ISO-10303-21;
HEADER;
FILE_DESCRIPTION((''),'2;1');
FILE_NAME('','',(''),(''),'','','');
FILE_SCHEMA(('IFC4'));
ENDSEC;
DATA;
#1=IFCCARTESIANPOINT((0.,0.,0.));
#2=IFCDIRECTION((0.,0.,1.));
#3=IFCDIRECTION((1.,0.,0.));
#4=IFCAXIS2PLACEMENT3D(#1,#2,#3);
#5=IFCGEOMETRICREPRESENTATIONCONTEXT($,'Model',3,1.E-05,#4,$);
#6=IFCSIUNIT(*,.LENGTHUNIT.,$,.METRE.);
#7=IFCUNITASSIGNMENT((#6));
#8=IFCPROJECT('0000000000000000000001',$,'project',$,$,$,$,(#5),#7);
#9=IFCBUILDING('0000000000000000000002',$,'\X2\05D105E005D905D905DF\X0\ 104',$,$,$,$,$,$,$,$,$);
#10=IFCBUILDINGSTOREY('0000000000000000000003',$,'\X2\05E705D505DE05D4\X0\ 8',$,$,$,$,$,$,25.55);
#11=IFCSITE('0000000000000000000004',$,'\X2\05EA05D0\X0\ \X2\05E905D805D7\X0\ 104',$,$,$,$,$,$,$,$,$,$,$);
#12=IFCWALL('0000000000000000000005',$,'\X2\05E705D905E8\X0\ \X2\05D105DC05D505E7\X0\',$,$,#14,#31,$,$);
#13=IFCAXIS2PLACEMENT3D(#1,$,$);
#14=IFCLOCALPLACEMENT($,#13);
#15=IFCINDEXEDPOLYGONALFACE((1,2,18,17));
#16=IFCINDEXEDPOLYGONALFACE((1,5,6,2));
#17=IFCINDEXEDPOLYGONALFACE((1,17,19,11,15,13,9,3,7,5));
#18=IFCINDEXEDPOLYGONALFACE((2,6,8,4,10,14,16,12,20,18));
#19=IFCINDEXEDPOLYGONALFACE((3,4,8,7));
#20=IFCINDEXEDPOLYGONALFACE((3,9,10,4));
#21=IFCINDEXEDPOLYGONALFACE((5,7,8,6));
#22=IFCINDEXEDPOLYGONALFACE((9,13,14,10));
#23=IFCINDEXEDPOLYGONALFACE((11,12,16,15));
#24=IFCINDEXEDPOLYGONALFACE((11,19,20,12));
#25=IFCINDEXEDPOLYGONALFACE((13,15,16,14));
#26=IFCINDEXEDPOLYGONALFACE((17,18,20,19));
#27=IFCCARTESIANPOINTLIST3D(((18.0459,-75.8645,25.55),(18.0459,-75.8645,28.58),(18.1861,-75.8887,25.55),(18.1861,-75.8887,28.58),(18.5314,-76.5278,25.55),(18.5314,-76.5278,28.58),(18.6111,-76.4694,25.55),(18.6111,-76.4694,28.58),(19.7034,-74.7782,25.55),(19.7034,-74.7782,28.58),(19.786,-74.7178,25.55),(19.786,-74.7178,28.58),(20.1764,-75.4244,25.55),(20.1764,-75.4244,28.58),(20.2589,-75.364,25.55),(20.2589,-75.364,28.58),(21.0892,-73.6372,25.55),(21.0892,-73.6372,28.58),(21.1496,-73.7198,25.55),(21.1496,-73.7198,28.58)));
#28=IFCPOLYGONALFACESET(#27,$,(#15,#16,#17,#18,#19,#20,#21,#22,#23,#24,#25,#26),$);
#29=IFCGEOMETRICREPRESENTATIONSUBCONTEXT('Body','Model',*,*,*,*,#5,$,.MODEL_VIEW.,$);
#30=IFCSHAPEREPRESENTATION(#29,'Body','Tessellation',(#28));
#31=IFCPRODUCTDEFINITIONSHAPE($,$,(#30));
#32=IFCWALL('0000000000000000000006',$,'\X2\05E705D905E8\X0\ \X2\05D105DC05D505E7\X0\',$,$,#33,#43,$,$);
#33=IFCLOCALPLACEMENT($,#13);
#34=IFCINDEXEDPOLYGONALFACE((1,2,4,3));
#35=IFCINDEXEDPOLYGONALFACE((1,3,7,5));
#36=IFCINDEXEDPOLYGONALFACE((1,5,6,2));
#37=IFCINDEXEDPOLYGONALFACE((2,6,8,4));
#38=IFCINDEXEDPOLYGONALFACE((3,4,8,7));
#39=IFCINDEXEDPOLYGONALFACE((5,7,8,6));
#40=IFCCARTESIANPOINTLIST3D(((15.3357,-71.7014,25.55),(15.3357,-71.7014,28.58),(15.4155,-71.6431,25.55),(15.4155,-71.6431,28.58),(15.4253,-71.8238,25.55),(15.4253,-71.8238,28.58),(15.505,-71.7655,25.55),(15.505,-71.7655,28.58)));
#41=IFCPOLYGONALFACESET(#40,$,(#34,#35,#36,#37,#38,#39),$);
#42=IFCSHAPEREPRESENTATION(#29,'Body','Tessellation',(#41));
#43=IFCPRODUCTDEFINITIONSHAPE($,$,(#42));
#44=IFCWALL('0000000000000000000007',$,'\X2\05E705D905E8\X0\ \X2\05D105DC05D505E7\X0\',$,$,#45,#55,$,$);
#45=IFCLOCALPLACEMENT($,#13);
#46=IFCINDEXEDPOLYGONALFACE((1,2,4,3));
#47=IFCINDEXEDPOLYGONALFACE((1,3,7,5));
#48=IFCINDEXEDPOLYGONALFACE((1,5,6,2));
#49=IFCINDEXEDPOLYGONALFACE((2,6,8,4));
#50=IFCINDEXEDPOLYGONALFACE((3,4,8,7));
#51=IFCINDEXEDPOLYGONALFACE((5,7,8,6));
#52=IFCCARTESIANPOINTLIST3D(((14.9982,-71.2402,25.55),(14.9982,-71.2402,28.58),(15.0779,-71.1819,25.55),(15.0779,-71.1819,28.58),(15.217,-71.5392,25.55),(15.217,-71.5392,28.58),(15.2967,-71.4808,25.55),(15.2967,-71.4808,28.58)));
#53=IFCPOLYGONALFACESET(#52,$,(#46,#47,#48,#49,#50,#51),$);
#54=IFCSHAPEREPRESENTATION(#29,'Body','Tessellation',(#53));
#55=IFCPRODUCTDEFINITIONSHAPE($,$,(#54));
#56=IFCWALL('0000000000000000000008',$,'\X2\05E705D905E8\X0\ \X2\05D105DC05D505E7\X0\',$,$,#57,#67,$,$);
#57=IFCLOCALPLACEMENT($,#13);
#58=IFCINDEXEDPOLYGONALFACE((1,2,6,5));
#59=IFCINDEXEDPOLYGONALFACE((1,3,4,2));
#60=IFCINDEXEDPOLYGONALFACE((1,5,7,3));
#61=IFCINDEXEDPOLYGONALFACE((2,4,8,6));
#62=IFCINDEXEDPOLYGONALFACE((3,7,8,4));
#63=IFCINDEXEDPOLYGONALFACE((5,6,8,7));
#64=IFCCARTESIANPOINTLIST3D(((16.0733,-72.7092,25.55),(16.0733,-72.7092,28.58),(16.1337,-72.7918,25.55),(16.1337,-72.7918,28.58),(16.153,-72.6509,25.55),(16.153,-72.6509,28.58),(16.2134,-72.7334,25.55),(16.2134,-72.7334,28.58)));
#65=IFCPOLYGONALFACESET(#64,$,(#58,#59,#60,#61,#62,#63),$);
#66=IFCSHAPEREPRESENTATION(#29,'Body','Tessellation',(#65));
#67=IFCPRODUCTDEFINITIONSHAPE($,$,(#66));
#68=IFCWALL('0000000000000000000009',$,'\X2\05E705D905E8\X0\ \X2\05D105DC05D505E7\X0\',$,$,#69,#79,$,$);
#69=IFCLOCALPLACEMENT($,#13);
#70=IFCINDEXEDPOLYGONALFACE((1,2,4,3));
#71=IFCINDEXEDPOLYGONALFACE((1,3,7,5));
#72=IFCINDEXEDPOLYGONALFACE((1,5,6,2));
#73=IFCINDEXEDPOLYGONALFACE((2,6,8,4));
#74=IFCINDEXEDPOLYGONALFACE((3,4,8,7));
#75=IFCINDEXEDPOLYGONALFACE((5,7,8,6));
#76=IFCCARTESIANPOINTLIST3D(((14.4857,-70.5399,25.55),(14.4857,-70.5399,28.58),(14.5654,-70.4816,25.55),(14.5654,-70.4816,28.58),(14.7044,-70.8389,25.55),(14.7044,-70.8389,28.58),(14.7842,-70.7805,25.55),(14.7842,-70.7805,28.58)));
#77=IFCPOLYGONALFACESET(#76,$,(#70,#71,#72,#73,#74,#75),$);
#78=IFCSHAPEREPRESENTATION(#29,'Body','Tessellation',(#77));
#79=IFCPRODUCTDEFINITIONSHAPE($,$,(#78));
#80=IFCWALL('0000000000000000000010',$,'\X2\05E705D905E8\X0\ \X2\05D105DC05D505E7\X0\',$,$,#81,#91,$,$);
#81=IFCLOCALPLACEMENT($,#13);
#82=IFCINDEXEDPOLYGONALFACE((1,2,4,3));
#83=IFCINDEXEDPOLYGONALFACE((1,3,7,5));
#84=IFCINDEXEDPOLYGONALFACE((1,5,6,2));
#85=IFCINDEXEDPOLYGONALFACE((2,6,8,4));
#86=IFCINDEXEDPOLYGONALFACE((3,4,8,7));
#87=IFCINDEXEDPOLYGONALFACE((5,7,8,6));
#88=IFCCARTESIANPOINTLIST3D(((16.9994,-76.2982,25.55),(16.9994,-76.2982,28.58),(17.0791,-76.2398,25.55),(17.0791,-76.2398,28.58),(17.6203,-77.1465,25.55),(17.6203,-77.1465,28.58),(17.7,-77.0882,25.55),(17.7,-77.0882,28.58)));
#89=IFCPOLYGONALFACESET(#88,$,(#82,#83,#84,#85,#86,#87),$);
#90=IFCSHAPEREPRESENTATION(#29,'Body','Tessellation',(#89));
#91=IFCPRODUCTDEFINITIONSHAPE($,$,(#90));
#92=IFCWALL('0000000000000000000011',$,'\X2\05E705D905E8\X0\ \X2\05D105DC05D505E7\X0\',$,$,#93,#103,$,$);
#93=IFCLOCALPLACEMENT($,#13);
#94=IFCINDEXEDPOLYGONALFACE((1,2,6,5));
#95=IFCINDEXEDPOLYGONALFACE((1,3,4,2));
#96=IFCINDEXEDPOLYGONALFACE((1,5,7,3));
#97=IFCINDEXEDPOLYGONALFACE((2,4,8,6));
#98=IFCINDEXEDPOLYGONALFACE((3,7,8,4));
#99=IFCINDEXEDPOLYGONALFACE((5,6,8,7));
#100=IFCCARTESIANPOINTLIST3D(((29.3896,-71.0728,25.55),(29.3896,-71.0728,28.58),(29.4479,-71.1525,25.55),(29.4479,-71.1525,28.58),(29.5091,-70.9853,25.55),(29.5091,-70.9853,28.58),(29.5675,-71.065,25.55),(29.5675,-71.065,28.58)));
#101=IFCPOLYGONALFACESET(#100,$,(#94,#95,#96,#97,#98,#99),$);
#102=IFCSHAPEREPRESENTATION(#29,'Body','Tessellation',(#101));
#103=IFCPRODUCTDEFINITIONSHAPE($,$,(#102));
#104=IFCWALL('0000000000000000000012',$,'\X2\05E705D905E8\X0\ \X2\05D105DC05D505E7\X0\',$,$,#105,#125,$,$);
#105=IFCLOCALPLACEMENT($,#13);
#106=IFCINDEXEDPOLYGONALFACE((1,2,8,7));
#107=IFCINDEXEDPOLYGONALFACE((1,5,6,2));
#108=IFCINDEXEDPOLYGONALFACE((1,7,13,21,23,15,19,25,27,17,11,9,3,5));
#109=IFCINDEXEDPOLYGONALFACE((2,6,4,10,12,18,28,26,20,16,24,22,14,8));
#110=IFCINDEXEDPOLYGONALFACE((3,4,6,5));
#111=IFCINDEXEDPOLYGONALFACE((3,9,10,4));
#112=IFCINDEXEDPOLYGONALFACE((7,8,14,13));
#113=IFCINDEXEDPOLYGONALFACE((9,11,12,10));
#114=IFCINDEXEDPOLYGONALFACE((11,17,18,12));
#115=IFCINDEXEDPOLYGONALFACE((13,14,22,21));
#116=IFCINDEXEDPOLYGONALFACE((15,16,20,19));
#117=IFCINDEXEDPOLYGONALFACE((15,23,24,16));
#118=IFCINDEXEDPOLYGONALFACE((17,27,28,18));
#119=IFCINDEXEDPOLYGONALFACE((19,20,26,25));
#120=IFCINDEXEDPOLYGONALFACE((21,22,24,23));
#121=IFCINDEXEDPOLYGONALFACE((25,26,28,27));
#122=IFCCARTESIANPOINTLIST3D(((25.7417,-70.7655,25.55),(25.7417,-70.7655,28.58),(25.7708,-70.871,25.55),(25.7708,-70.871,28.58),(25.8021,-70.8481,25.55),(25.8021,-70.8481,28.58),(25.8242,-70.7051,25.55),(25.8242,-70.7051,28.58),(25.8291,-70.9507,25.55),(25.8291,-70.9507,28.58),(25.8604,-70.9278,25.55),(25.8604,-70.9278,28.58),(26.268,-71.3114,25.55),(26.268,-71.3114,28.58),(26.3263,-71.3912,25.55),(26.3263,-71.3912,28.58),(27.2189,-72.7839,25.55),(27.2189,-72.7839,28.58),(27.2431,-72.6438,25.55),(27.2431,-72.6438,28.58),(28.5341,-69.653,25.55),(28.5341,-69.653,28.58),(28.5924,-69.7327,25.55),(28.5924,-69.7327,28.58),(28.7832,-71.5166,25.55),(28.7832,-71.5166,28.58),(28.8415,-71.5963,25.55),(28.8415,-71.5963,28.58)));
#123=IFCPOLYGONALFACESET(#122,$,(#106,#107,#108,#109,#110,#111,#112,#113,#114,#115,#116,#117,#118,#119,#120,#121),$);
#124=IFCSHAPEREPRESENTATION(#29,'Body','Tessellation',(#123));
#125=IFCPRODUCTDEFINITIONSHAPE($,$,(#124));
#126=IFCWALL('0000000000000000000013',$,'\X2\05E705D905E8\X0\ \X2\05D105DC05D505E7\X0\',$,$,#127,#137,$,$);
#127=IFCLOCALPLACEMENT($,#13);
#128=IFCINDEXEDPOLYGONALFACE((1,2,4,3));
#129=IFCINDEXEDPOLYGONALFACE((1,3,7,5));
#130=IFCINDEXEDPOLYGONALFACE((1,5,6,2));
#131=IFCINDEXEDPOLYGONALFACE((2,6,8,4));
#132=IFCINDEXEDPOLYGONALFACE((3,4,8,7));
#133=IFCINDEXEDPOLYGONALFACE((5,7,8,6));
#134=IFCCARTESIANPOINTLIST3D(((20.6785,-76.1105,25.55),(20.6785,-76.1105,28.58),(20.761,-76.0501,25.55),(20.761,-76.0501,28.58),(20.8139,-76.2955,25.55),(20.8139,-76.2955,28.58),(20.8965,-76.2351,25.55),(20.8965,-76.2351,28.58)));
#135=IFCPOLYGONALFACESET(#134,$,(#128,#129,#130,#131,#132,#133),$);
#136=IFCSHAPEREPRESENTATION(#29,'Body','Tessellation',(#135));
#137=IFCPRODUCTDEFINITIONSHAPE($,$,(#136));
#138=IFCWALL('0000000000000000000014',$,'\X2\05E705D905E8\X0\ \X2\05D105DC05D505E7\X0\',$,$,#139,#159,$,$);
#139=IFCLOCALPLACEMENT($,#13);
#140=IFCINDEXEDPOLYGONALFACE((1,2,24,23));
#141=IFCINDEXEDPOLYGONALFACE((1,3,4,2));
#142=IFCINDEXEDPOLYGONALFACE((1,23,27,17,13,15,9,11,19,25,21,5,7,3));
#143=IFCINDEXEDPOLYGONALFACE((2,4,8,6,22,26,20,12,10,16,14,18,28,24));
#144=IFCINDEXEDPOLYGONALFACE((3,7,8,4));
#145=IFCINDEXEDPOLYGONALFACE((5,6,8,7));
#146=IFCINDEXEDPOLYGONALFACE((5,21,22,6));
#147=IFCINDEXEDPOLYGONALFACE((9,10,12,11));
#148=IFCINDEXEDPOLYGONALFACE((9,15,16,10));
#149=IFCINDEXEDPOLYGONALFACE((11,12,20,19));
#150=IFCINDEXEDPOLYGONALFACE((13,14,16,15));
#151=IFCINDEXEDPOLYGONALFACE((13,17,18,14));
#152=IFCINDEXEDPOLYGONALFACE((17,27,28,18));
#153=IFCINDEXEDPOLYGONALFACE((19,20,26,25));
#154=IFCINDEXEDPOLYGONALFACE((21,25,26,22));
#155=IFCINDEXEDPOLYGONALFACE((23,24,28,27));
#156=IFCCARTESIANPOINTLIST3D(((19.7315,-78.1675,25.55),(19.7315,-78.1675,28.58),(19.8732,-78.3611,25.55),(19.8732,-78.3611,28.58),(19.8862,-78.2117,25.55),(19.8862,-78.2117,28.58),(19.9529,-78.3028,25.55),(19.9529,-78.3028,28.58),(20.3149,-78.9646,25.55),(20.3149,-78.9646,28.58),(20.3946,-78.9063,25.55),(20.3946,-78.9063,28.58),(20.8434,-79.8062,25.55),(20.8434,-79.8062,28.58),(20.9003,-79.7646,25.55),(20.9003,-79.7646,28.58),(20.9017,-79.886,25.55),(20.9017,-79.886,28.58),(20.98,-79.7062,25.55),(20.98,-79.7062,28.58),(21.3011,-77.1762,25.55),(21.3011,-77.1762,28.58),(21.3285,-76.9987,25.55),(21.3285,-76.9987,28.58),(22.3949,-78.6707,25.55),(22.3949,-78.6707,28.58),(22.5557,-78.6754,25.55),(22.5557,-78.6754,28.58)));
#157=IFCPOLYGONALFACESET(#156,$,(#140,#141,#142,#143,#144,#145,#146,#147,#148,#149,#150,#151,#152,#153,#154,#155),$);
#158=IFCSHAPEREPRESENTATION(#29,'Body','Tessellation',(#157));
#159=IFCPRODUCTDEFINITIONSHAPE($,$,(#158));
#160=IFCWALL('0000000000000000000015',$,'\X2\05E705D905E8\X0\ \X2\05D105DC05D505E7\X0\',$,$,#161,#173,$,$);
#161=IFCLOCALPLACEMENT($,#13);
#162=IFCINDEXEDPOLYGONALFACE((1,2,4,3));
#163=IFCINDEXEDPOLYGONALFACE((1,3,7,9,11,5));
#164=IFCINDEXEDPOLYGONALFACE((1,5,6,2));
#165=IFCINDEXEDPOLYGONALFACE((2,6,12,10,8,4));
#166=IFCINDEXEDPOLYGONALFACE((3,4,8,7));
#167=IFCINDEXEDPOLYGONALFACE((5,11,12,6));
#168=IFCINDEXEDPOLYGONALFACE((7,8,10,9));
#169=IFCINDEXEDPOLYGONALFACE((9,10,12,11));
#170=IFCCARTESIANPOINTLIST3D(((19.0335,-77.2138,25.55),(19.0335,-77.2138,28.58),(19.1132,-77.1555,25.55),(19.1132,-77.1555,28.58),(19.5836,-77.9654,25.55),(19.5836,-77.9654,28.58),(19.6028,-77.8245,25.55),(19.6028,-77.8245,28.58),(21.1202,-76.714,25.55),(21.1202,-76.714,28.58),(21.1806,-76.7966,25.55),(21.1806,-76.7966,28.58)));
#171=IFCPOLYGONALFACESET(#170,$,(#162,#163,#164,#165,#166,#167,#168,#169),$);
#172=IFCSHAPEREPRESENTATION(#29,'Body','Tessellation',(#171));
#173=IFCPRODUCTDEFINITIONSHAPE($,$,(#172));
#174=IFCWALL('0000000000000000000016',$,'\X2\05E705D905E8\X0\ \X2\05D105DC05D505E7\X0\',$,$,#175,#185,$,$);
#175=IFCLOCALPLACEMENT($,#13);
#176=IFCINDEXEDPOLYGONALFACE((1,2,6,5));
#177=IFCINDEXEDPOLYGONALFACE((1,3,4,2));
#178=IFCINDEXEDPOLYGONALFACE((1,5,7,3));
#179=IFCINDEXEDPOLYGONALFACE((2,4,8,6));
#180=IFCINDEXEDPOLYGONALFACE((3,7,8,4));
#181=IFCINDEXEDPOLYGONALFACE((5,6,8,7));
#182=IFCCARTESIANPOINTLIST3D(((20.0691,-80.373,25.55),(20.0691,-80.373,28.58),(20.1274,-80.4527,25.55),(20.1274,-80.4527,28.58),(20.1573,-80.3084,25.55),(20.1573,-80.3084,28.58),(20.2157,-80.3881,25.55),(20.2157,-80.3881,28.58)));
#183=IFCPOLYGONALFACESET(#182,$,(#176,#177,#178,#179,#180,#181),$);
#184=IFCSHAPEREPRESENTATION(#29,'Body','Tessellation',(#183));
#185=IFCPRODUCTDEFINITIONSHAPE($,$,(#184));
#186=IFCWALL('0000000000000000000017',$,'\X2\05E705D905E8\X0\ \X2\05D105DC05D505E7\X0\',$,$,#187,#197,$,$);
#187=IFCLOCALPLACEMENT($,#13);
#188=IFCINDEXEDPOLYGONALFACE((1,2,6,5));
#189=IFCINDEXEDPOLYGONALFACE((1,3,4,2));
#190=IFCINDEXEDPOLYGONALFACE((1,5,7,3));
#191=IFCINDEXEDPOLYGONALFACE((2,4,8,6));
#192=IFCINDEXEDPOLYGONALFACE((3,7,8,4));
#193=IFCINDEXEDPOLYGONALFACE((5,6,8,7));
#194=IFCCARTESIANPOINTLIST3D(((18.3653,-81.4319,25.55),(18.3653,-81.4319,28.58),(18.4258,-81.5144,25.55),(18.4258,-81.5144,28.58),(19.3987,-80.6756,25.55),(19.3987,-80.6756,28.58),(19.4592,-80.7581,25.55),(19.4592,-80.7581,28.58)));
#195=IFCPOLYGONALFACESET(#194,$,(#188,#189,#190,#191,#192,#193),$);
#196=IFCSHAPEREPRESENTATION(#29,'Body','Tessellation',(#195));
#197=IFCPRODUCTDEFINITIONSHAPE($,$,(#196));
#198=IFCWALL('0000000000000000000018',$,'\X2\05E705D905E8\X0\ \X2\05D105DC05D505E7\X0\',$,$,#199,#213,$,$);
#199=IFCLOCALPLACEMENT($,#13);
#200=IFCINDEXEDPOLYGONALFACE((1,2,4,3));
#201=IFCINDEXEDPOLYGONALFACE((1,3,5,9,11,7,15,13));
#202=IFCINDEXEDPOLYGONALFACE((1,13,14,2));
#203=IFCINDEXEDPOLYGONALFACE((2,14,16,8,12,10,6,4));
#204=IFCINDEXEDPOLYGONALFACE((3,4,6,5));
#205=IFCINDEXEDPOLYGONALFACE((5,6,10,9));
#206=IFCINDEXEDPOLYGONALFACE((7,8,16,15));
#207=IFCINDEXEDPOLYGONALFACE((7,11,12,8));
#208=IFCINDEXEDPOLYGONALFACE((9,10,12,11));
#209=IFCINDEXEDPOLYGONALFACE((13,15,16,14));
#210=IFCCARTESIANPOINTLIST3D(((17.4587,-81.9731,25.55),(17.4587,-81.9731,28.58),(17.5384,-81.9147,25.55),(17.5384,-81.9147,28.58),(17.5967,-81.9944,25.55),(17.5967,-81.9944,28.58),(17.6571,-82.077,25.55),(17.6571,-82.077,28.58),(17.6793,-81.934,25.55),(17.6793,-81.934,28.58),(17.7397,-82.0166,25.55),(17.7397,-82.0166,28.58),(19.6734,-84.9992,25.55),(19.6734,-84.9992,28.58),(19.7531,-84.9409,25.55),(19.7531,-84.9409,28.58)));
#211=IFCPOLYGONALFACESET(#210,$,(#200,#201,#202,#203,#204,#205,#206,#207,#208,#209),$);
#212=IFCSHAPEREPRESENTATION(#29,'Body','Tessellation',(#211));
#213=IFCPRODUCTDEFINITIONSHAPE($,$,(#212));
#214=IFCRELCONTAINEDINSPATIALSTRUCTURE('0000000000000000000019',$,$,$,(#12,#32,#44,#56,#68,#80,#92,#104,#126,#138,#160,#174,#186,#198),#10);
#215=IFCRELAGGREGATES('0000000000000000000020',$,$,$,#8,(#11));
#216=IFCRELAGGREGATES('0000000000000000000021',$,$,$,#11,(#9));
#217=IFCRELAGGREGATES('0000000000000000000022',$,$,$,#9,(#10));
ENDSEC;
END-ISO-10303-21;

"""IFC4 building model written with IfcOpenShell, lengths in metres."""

from ifc_helpers import new_model, si_unit, frame, origin_with_axes, context, subcontext, project, spatial, polyline, outline, extrude, element, save


model = new_model("IFC4")

# Units and contexts
model_context = context("Model", 3, precision=1e-05, world=origin_with_axes())
body_context = subcontext(model_context, "Body", "Model", "MODEL_VIEW")
ifc_project = project(units=[si_unit("LENGTHUNIT", "METRE")], contexts=[model_context])

# Site, building, storey
site = spatial("IfcSite", under=ifc_project, Name="תא שטח 104")
building = spatial("IfcBuilding", under=site, Name="בניין 104")
storey = spatial("IfcBuildingStorey", under=building, Name="קומה 8", Elevation=25.55)

# Walls
element("IfcWall", 1, inside=storey, Name="קיר בלוק", context=body_context, shape_type="SweptSolid", body=[
    extrude(outline(polyline([(19.7034, -74.7782), (20.1764, -75.4244), (20.2589, -75.364), (19.786, -74.7178), (21.1496, -73.7198), (21.0892, -73.6372), (18.0459, -75.8645), (18.5314, -76.5278), (18.6111, -76.4694), (18.1861, -75.8887), (19.7034, -74.7782)])), frame((0.0, 0.0, 25.55)), (0.0, 0.0, 1.0), 3.03),
])
element("IfcWall", 2, inside=storey, Name="קיר בלוק", context=body_context, shape_type="SweptSolid", body=[
    extrude(outline(polyline([(15.3357, -71.7014), (15.4253, -71.8238), (15.505, -71.7655), (15.4155, -71.6431), (15.3357, -71.7014)])), frame((0.0, 0.0, 25.55)), (0.0, 0.0, 1.0), 3.03),
])
element("IfcWall", 3, inside=storey, Name="קיר בלוק", context=body_context, shape_type="SweptSolid", body=[
    extrude(outline(polyline([(15.0779, -71.1819), (14.9982, -71.2403), (15.217, -71.5392), (15.2967, -71.4808), (15.0779, -71.1819)])), frame((0.0, 0.0, 25.55)), (0.0, 0.0, 1.0), 3.03),
])
element("IfcWall", 4, inside=storey, Name="קיר בלוק", context=body_context, shape_type="SweptSolid", body=[
    extrude(outline(polyline([(16.2134, -72.7334), (16.153, -72.6509), (16.0733, -72.7092), (16.1337, -72.7918), (16.2134, -72.7334)])), frame((0.0, 0.0, 25.55)), (0.0, 0.0, 1.0), 3.03),
])
element("IfcWall", 5, inside=storey, Name="קיר בלוק", context=body_context, shape_type="SweptSolid", body=[
    extrude(outline(polyline([(14.7044, -70.8389), (14.7841, -70.7805), (14.5654, -70.4816), (14.4857, -70.5399), (14.7044, -70.8389)])), frame((0.0, 0.0, 25.55)), (0.0, 0.0, 1.0), 3.03),
])
element("IfcWall", 6, inside=storey, Name="קיר בלוק", context=body_context, shape_type="SweptSolid", body=[
    extrude(outline(polyline([(17.6203, -77.1465), (17.7, -77.0882), (17.0791, -76.2398), (16.9994, -76.2982), (17.6203, -77.1465)])), frame((0.0, 0.0, 25.55)), (0.0, 0.0, 1.0), 3.03),
])
element("IfcWall", 7, inside=storey, Name="קיר בלוק", context=body_context, shape_type="SweptSolid", body=[
    extrude(outline(polyline([(29.5675, -71.065), (29.5091, -70.9853), (29.3896, -71.0728), (29.4479, -71.1525), (29.5675, -71.065)])), frame((0.0, 0.0, 25.55)), (0.0, 0.0, 1.0), 3.03),
])
element("IfcWall", 8, inside=storey, Name="קיר בלוק", context=body_context, shape_type="SweptSolid", body=[
    extrude(outline(polyline([(25.8021, -70.8481), (25.7708, -70.871), (25.8291, -70.9507), (25.8604, -70.9278), (27.2189, -72.7839), (28.8415, -71.5963), (28.7832, -71.5166), (27.2431, -72.6438), (26.3263, -71.3912), (28.5924, -69.7327), (28.5341, -69.653), (26.268, -71.3114), (25.8242, -70.7051), (25.7417, -70.7655), (25.8021, -70.8481)])), frame((0.0, 0.0, 25.55)), (0.0, 0.0, 1.0), 3.03),
])
element("IfcWall", 9, inside=storey, Name="קיר בלוק", context=body_context, shape_type="SweptSolid", body=[
    extrude(outline(polyline([(20.8965, -76.2351), (20.761, -76.0501), (20.6785, -76.1105), (20.8139, -76.2955), (20.8965, -76.2351)])), frame((0.0, 0.0, 25.55)), (0.0, 0.0, 1.0), 3.03),
])
element("IfcWall", 10, inside=storey, Name="קיר בלוק", context=body_context, shape_type="SweptSolid", body=[
    extrude(outline(polyline([(21.3285, -76.9987), (19.7315, -78.1675), (19.8732, -78.3611), (19.9529, -78.3028), (19.8862, -78.2117), (21.3011, -77.1762), (22.3949, -78.6707), (20.98, -79.7062), (20.3946, -78.9063), (20.3149, -78.9646), (20.9003, -79.7646), (20.8434, -79.8062), (20.9017, -79.886), (22.5557, -78.6754), (21.3285, -76.9987)])), frame((0.0, 0.0, 25.55)), (0.0, 0.0, 1.0), 3.03),
])
element("IfcWall", 11, inside=storey, Name="קיר בלוק", context=body_context, shape_type="SweptSolid", body=[
    extrude(outline(polyline([(19.0335, -77.2138), (19.5836, -77.9654), (21.1806, -76.7966), (21.1202, -76.714), (19.6028, -77.8245), (19.1132, -77.1555), (19.0335, -77.2138)])), frame((0.0, 0.0, 25.55)), (0.0, 0.0, 1.0), 3.03),
])
element("IfcWall", 12, inside=storey, Name="קיר בלוק", context=body_context, shape_type="SweptSolid", body=[
    extrude(outline(polyline([(20.2157, -80.3881), (20.1573, -80.3084), (20.0691, -80.373), (20.1274, -80.4527), (20.2157, -80.3881)])), frame((0.0, 0.0, 25.55)), (0.0, 0.0, 1.0), 3.03),
])
element("IfcWall", 13, inside=storey, Name="קיר בלוק", context=body_context, shape_type="SweptSolid", body=[
    extrude(outline(polyline([(19.4592, -80.7581), (19.3987, -80.6756), (18.3653, -81.4319), (18.4258, -81.5144), (19.4592, -80.7581)])), frame((0.0, 0.0, 25.55)), (0.0, 0.0, 1.0), 3.03),
])
element("IfcWall", 14, inside=storey, Name="קיר בלוק", context=body_context, shape_type="SweptSolid", body=[
    extrude(outline(polyline([(17.4587, -81.9731), (19.6734, -84.9992), (19.7531, -84.9409), (17.6571, -82.077), (17.7397, -82.0166), (17.6793, -81.934), (17.5967, -81.9944), (17.5384, -81.9147), (17.4587, -81.9731)])), frame((0.0, 0.0, 25.55)), (0.0, 0.0, 1.0), 3.03),
])

save(model, "model.ifc")
